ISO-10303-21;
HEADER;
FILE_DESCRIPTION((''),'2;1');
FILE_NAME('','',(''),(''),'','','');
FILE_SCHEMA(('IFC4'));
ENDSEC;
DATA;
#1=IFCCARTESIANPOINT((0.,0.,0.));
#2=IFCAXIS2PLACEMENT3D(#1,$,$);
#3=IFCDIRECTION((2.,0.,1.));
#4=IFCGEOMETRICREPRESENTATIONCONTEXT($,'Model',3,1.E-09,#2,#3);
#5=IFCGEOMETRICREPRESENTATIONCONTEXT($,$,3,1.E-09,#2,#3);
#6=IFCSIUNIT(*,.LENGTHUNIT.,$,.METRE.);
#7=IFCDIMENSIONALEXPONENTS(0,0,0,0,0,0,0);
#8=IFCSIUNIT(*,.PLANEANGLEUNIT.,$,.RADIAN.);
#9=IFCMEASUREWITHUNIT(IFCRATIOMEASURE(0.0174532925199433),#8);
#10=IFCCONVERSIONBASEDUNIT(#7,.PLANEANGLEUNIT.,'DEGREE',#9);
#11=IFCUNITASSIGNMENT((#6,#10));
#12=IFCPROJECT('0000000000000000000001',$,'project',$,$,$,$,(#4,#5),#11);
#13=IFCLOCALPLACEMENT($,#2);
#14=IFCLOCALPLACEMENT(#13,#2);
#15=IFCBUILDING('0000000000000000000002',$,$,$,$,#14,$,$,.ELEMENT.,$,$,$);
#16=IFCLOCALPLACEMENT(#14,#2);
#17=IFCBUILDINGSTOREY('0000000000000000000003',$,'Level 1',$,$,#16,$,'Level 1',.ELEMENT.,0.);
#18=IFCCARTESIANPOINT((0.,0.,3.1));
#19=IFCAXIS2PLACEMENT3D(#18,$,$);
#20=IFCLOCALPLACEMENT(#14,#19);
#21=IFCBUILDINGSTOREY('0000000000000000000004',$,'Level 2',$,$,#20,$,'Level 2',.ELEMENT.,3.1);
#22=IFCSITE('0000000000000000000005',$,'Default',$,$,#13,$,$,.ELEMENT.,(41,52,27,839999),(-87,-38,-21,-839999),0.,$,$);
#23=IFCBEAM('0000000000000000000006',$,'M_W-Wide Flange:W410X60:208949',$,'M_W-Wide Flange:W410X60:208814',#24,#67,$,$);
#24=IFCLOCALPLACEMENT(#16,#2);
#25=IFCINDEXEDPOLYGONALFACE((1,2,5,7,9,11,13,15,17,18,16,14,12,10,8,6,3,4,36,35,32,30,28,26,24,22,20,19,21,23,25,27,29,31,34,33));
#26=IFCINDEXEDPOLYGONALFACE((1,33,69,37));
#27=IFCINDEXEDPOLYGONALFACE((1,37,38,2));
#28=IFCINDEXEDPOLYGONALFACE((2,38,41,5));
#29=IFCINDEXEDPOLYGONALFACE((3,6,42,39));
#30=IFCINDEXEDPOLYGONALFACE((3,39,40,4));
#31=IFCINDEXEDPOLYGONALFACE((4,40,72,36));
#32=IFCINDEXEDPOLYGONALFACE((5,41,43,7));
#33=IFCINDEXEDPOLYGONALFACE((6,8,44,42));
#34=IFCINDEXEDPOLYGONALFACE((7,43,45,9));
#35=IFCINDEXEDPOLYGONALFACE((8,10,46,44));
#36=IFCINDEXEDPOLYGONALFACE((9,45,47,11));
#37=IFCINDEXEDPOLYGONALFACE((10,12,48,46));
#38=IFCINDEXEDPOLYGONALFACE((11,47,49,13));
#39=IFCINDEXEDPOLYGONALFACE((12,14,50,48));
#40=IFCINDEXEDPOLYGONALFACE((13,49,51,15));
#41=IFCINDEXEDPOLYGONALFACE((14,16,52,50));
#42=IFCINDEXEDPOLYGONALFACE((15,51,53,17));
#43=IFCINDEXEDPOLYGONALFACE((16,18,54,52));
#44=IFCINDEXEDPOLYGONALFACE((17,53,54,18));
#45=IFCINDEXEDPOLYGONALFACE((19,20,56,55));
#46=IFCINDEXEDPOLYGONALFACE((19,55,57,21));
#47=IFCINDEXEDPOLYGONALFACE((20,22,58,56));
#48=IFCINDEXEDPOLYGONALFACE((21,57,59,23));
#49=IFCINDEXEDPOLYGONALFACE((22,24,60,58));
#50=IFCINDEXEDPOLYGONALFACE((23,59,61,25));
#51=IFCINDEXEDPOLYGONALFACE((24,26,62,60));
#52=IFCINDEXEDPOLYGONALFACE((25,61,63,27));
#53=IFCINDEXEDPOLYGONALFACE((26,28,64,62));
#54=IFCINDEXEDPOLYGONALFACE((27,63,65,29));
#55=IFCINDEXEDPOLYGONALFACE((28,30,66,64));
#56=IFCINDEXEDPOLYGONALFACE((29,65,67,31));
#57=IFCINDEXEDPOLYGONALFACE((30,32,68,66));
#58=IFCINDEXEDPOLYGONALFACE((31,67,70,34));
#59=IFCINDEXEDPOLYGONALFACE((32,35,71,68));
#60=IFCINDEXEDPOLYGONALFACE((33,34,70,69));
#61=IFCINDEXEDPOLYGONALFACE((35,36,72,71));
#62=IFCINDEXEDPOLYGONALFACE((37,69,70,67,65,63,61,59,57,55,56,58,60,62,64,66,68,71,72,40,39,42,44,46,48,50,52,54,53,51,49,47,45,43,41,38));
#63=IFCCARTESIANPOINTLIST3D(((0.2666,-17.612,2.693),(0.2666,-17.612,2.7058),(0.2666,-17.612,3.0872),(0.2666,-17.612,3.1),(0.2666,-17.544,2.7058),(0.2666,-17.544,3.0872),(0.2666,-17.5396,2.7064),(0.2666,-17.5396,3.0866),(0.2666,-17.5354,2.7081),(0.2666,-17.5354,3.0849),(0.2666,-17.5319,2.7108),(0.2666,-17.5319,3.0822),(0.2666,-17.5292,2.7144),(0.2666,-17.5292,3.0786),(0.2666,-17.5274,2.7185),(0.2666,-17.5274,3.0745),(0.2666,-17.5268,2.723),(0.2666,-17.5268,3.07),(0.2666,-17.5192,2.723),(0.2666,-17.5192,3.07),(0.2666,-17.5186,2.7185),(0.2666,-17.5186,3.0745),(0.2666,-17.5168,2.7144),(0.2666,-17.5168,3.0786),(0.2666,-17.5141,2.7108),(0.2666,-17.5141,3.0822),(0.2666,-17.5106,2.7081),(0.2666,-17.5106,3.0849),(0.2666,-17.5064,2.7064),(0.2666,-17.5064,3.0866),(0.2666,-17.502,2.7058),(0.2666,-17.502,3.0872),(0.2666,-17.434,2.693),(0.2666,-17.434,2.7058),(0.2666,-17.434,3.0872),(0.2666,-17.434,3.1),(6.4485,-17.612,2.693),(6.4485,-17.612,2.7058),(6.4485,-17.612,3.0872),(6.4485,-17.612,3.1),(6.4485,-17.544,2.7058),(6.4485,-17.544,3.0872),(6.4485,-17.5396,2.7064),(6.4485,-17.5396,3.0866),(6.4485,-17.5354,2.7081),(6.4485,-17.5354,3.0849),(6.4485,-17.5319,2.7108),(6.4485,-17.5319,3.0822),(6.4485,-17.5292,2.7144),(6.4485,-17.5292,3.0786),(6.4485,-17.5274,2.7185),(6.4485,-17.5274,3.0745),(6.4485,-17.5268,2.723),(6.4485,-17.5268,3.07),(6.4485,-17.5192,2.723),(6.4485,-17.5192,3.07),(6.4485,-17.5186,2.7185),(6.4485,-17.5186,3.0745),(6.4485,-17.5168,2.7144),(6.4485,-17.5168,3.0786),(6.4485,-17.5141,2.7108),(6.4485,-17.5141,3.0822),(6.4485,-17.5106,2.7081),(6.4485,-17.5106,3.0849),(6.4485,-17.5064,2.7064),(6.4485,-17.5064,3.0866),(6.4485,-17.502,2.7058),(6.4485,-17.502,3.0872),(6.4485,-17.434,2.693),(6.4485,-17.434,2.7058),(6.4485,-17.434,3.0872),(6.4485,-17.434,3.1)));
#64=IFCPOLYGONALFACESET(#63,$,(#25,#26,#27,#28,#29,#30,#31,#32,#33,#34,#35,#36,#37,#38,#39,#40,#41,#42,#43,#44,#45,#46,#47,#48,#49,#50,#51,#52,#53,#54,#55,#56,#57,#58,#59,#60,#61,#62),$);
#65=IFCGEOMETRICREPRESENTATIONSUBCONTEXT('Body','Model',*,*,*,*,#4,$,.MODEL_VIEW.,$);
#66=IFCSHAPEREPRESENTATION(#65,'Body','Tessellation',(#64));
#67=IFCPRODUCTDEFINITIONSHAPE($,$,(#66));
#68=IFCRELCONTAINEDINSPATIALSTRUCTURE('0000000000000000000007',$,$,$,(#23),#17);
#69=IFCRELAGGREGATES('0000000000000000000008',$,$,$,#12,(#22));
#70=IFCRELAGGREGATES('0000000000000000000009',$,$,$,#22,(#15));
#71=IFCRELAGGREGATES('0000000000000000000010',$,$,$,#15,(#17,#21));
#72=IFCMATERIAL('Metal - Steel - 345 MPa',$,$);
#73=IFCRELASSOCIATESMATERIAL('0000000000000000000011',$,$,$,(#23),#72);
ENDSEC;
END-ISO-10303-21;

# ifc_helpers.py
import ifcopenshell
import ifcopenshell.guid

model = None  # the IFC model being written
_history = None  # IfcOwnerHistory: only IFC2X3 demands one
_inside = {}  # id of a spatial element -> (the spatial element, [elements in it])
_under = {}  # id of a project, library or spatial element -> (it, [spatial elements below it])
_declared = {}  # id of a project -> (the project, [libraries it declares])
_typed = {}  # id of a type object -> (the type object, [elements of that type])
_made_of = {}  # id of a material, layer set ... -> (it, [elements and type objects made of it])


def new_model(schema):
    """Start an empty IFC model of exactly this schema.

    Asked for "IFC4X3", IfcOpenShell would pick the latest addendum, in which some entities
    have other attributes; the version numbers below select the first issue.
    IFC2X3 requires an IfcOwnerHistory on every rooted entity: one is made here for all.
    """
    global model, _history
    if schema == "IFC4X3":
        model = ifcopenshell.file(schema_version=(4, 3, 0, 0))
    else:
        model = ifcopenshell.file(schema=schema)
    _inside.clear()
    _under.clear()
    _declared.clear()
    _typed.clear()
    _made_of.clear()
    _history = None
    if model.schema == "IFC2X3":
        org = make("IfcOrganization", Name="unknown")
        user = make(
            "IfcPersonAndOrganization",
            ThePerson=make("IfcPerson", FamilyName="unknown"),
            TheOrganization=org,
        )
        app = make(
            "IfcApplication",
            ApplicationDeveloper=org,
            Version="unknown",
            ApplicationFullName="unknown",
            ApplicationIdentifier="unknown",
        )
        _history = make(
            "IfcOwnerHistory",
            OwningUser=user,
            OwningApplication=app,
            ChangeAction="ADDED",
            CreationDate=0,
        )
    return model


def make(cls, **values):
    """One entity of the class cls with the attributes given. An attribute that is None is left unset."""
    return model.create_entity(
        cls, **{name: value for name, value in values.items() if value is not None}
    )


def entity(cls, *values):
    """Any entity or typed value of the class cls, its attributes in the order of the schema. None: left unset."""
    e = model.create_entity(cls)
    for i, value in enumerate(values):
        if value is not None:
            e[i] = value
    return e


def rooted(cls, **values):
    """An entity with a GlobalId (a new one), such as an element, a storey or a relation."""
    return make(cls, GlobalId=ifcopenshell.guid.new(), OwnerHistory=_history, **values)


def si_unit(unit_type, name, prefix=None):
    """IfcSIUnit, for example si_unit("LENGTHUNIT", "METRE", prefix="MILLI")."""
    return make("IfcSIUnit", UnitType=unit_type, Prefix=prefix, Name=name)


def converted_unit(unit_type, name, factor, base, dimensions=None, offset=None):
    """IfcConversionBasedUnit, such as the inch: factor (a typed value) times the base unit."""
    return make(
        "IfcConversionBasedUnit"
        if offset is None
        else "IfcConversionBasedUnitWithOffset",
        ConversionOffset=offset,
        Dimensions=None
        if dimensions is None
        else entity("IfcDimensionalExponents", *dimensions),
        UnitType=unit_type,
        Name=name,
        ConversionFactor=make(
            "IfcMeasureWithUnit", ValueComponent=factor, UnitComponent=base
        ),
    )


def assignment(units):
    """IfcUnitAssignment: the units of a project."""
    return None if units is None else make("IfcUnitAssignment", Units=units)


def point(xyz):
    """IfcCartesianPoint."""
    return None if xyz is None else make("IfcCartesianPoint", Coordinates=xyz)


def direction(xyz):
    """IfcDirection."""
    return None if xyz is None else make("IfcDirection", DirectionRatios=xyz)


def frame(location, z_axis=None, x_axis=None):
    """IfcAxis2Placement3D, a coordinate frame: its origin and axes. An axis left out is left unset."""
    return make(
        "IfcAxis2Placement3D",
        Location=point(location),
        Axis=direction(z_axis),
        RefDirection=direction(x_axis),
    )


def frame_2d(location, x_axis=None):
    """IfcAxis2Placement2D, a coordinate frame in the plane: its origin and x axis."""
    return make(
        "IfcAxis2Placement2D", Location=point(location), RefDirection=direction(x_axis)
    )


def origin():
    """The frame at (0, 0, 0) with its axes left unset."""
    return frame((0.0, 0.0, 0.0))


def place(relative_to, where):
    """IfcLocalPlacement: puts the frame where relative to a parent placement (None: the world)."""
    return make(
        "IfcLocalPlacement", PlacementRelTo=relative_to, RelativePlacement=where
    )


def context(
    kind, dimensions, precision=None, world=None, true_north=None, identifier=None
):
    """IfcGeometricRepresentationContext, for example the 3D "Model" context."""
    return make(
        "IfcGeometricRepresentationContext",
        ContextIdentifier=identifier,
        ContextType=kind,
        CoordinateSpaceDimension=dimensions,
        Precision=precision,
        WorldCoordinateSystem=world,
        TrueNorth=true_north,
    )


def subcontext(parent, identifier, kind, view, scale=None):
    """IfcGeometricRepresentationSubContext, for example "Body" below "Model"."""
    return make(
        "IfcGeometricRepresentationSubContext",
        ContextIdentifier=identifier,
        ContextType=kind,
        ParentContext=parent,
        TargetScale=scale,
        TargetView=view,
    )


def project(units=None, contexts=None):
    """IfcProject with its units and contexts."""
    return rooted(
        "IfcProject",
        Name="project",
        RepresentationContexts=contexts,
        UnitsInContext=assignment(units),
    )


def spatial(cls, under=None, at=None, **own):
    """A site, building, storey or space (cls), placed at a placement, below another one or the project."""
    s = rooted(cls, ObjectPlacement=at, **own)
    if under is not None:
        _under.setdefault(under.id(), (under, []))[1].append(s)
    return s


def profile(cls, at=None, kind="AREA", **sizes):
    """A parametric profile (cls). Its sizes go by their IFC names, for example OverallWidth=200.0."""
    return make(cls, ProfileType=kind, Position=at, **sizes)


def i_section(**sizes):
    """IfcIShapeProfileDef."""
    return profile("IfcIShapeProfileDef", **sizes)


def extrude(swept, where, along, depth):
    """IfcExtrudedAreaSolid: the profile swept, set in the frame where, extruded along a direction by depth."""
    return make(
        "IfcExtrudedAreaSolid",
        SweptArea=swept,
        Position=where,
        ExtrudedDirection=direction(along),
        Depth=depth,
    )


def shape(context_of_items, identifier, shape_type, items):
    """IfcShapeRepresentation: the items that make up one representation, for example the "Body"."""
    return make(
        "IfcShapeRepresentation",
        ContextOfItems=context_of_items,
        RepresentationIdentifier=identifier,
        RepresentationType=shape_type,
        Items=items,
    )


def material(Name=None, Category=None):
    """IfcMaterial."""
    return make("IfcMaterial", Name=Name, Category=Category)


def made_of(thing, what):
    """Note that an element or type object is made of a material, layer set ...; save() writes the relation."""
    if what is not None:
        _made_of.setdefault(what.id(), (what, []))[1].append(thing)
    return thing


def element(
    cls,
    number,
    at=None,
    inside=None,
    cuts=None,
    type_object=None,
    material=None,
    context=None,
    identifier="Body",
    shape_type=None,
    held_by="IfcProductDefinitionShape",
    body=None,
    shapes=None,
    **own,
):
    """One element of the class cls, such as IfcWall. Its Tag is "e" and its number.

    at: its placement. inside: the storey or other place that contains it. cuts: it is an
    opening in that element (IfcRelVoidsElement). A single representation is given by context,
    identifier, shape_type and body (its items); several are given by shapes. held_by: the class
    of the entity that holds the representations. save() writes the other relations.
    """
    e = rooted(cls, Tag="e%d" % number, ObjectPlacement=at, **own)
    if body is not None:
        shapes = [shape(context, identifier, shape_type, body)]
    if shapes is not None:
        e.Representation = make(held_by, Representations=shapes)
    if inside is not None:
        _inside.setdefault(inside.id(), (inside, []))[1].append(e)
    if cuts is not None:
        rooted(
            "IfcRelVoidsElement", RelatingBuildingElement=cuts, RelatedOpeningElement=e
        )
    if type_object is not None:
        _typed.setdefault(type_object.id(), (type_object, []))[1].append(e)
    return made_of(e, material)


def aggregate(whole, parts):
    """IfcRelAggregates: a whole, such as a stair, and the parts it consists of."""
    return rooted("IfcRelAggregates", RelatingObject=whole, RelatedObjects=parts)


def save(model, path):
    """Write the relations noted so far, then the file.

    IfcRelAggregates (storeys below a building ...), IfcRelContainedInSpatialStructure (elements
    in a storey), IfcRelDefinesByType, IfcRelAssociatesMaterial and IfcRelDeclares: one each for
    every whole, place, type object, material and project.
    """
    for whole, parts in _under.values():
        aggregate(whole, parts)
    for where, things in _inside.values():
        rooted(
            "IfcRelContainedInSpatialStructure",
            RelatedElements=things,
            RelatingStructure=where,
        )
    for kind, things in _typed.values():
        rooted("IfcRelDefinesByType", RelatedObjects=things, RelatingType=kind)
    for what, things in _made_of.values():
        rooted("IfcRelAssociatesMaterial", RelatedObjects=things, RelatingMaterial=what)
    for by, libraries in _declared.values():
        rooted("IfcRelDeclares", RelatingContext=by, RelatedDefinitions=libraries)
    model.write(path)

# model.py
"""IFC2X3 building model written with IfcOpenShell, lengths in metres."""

from ifc_helpers import new_model, entity, si_unit, converted_unit, direction, frame, frame_2d, origin, place, context, subcontext, project, spatial, i_section, extrude, material, element, save


model = new_model("IFC2X3")

# Units and contexts
model_context = context("Model", 3, precision=1e-09, world=origin(), true_north=direction((2.0, 0.0, 1.0)))
context_of_model = context(None, 3, precision=1e-09, world=origin(), true_north=direction((2.0, 0.0, 1.0)))
body_context = subcontext(model_context, "Body", "Model", "MODEL_VIEW")
ifc_project = project(units=[si_unit("LENGTHUNIT", "METRE"), converted_unit("PLANEANGLEUNIT", "DEGREE", entity("IfcRatioMeasure", 0.0174532925199433), si_unit("PLANEANGLEUNIT", "RADIAN"), dimensions=[0, 0, 0, 0, 0, 0, 0])], contexts=[model_context, context_of_model])

# Site, building, storey
site_placement = place(None, origin())
site = spatial("IfcSite", under=ifc_project, at=site_placement, Name="Default", CompositionType="ELEMENT", RefLatitude=(41, 52, 27, 839999), RefLongitude=(-87, -38, -21, -839999), RefElevation=0.0)
building_placement = place(site_placement, origin())
building = spatial("IfcBuilding", under=site, at=building_placement, CompositionType="ELEMENT")
storey_1_placement = place(building_placement, origin())
storey_1 = spatial("IfcBuildingStorey", under=building, at=storey_1_placement, Name="Level 1", LongName="Level 1", CompositionType="ELEMENT", Elevation=0.0)

# Beam
ifc_material_1 = material(Name="Metal - Steel - 345 MPa")
beam_placement = place(storey_1_placement, frame((0.2666, -17.523, 3.1)))
element("IfcBeam", 1, at=beam_placement, inside=storey_1, material=ifc_material_1, Name="M_W-Wide Flange:W410X60:208949", ObjectType="M_W-Wide Flange:W410X60:208814", context=body_context, shape_type="SweptSolid", body=[
    extrude(i_section(OverallWidth=0.178, OverallDepth=0.407, WebThickness=0.0077, FlangeThickness=0.0128, FilletRadius=0.0172, at=frame_2d((0.0, 0.0), x_axis=(0.0, 1.0))), frame((0.0, 0.0, -0.2035), z_axis=(1.0, 0.0, 0.0), x_axis=(0.0, 0.0, -1.0)), (0.0, 0.0, 1.0), 6.1819),
])

# Shared definitions
storey_2_placement = place(building_placement, frame((0.0, 0.0, 3.1)))
storey_2 = spatial("IfcBuildingStorey", under=building, at=storey_2_placement, Name="Level 2", LongName="Level 2", CompositionType="ELEMENT", Elevation=3.1)

save(model, "model.ifc")
